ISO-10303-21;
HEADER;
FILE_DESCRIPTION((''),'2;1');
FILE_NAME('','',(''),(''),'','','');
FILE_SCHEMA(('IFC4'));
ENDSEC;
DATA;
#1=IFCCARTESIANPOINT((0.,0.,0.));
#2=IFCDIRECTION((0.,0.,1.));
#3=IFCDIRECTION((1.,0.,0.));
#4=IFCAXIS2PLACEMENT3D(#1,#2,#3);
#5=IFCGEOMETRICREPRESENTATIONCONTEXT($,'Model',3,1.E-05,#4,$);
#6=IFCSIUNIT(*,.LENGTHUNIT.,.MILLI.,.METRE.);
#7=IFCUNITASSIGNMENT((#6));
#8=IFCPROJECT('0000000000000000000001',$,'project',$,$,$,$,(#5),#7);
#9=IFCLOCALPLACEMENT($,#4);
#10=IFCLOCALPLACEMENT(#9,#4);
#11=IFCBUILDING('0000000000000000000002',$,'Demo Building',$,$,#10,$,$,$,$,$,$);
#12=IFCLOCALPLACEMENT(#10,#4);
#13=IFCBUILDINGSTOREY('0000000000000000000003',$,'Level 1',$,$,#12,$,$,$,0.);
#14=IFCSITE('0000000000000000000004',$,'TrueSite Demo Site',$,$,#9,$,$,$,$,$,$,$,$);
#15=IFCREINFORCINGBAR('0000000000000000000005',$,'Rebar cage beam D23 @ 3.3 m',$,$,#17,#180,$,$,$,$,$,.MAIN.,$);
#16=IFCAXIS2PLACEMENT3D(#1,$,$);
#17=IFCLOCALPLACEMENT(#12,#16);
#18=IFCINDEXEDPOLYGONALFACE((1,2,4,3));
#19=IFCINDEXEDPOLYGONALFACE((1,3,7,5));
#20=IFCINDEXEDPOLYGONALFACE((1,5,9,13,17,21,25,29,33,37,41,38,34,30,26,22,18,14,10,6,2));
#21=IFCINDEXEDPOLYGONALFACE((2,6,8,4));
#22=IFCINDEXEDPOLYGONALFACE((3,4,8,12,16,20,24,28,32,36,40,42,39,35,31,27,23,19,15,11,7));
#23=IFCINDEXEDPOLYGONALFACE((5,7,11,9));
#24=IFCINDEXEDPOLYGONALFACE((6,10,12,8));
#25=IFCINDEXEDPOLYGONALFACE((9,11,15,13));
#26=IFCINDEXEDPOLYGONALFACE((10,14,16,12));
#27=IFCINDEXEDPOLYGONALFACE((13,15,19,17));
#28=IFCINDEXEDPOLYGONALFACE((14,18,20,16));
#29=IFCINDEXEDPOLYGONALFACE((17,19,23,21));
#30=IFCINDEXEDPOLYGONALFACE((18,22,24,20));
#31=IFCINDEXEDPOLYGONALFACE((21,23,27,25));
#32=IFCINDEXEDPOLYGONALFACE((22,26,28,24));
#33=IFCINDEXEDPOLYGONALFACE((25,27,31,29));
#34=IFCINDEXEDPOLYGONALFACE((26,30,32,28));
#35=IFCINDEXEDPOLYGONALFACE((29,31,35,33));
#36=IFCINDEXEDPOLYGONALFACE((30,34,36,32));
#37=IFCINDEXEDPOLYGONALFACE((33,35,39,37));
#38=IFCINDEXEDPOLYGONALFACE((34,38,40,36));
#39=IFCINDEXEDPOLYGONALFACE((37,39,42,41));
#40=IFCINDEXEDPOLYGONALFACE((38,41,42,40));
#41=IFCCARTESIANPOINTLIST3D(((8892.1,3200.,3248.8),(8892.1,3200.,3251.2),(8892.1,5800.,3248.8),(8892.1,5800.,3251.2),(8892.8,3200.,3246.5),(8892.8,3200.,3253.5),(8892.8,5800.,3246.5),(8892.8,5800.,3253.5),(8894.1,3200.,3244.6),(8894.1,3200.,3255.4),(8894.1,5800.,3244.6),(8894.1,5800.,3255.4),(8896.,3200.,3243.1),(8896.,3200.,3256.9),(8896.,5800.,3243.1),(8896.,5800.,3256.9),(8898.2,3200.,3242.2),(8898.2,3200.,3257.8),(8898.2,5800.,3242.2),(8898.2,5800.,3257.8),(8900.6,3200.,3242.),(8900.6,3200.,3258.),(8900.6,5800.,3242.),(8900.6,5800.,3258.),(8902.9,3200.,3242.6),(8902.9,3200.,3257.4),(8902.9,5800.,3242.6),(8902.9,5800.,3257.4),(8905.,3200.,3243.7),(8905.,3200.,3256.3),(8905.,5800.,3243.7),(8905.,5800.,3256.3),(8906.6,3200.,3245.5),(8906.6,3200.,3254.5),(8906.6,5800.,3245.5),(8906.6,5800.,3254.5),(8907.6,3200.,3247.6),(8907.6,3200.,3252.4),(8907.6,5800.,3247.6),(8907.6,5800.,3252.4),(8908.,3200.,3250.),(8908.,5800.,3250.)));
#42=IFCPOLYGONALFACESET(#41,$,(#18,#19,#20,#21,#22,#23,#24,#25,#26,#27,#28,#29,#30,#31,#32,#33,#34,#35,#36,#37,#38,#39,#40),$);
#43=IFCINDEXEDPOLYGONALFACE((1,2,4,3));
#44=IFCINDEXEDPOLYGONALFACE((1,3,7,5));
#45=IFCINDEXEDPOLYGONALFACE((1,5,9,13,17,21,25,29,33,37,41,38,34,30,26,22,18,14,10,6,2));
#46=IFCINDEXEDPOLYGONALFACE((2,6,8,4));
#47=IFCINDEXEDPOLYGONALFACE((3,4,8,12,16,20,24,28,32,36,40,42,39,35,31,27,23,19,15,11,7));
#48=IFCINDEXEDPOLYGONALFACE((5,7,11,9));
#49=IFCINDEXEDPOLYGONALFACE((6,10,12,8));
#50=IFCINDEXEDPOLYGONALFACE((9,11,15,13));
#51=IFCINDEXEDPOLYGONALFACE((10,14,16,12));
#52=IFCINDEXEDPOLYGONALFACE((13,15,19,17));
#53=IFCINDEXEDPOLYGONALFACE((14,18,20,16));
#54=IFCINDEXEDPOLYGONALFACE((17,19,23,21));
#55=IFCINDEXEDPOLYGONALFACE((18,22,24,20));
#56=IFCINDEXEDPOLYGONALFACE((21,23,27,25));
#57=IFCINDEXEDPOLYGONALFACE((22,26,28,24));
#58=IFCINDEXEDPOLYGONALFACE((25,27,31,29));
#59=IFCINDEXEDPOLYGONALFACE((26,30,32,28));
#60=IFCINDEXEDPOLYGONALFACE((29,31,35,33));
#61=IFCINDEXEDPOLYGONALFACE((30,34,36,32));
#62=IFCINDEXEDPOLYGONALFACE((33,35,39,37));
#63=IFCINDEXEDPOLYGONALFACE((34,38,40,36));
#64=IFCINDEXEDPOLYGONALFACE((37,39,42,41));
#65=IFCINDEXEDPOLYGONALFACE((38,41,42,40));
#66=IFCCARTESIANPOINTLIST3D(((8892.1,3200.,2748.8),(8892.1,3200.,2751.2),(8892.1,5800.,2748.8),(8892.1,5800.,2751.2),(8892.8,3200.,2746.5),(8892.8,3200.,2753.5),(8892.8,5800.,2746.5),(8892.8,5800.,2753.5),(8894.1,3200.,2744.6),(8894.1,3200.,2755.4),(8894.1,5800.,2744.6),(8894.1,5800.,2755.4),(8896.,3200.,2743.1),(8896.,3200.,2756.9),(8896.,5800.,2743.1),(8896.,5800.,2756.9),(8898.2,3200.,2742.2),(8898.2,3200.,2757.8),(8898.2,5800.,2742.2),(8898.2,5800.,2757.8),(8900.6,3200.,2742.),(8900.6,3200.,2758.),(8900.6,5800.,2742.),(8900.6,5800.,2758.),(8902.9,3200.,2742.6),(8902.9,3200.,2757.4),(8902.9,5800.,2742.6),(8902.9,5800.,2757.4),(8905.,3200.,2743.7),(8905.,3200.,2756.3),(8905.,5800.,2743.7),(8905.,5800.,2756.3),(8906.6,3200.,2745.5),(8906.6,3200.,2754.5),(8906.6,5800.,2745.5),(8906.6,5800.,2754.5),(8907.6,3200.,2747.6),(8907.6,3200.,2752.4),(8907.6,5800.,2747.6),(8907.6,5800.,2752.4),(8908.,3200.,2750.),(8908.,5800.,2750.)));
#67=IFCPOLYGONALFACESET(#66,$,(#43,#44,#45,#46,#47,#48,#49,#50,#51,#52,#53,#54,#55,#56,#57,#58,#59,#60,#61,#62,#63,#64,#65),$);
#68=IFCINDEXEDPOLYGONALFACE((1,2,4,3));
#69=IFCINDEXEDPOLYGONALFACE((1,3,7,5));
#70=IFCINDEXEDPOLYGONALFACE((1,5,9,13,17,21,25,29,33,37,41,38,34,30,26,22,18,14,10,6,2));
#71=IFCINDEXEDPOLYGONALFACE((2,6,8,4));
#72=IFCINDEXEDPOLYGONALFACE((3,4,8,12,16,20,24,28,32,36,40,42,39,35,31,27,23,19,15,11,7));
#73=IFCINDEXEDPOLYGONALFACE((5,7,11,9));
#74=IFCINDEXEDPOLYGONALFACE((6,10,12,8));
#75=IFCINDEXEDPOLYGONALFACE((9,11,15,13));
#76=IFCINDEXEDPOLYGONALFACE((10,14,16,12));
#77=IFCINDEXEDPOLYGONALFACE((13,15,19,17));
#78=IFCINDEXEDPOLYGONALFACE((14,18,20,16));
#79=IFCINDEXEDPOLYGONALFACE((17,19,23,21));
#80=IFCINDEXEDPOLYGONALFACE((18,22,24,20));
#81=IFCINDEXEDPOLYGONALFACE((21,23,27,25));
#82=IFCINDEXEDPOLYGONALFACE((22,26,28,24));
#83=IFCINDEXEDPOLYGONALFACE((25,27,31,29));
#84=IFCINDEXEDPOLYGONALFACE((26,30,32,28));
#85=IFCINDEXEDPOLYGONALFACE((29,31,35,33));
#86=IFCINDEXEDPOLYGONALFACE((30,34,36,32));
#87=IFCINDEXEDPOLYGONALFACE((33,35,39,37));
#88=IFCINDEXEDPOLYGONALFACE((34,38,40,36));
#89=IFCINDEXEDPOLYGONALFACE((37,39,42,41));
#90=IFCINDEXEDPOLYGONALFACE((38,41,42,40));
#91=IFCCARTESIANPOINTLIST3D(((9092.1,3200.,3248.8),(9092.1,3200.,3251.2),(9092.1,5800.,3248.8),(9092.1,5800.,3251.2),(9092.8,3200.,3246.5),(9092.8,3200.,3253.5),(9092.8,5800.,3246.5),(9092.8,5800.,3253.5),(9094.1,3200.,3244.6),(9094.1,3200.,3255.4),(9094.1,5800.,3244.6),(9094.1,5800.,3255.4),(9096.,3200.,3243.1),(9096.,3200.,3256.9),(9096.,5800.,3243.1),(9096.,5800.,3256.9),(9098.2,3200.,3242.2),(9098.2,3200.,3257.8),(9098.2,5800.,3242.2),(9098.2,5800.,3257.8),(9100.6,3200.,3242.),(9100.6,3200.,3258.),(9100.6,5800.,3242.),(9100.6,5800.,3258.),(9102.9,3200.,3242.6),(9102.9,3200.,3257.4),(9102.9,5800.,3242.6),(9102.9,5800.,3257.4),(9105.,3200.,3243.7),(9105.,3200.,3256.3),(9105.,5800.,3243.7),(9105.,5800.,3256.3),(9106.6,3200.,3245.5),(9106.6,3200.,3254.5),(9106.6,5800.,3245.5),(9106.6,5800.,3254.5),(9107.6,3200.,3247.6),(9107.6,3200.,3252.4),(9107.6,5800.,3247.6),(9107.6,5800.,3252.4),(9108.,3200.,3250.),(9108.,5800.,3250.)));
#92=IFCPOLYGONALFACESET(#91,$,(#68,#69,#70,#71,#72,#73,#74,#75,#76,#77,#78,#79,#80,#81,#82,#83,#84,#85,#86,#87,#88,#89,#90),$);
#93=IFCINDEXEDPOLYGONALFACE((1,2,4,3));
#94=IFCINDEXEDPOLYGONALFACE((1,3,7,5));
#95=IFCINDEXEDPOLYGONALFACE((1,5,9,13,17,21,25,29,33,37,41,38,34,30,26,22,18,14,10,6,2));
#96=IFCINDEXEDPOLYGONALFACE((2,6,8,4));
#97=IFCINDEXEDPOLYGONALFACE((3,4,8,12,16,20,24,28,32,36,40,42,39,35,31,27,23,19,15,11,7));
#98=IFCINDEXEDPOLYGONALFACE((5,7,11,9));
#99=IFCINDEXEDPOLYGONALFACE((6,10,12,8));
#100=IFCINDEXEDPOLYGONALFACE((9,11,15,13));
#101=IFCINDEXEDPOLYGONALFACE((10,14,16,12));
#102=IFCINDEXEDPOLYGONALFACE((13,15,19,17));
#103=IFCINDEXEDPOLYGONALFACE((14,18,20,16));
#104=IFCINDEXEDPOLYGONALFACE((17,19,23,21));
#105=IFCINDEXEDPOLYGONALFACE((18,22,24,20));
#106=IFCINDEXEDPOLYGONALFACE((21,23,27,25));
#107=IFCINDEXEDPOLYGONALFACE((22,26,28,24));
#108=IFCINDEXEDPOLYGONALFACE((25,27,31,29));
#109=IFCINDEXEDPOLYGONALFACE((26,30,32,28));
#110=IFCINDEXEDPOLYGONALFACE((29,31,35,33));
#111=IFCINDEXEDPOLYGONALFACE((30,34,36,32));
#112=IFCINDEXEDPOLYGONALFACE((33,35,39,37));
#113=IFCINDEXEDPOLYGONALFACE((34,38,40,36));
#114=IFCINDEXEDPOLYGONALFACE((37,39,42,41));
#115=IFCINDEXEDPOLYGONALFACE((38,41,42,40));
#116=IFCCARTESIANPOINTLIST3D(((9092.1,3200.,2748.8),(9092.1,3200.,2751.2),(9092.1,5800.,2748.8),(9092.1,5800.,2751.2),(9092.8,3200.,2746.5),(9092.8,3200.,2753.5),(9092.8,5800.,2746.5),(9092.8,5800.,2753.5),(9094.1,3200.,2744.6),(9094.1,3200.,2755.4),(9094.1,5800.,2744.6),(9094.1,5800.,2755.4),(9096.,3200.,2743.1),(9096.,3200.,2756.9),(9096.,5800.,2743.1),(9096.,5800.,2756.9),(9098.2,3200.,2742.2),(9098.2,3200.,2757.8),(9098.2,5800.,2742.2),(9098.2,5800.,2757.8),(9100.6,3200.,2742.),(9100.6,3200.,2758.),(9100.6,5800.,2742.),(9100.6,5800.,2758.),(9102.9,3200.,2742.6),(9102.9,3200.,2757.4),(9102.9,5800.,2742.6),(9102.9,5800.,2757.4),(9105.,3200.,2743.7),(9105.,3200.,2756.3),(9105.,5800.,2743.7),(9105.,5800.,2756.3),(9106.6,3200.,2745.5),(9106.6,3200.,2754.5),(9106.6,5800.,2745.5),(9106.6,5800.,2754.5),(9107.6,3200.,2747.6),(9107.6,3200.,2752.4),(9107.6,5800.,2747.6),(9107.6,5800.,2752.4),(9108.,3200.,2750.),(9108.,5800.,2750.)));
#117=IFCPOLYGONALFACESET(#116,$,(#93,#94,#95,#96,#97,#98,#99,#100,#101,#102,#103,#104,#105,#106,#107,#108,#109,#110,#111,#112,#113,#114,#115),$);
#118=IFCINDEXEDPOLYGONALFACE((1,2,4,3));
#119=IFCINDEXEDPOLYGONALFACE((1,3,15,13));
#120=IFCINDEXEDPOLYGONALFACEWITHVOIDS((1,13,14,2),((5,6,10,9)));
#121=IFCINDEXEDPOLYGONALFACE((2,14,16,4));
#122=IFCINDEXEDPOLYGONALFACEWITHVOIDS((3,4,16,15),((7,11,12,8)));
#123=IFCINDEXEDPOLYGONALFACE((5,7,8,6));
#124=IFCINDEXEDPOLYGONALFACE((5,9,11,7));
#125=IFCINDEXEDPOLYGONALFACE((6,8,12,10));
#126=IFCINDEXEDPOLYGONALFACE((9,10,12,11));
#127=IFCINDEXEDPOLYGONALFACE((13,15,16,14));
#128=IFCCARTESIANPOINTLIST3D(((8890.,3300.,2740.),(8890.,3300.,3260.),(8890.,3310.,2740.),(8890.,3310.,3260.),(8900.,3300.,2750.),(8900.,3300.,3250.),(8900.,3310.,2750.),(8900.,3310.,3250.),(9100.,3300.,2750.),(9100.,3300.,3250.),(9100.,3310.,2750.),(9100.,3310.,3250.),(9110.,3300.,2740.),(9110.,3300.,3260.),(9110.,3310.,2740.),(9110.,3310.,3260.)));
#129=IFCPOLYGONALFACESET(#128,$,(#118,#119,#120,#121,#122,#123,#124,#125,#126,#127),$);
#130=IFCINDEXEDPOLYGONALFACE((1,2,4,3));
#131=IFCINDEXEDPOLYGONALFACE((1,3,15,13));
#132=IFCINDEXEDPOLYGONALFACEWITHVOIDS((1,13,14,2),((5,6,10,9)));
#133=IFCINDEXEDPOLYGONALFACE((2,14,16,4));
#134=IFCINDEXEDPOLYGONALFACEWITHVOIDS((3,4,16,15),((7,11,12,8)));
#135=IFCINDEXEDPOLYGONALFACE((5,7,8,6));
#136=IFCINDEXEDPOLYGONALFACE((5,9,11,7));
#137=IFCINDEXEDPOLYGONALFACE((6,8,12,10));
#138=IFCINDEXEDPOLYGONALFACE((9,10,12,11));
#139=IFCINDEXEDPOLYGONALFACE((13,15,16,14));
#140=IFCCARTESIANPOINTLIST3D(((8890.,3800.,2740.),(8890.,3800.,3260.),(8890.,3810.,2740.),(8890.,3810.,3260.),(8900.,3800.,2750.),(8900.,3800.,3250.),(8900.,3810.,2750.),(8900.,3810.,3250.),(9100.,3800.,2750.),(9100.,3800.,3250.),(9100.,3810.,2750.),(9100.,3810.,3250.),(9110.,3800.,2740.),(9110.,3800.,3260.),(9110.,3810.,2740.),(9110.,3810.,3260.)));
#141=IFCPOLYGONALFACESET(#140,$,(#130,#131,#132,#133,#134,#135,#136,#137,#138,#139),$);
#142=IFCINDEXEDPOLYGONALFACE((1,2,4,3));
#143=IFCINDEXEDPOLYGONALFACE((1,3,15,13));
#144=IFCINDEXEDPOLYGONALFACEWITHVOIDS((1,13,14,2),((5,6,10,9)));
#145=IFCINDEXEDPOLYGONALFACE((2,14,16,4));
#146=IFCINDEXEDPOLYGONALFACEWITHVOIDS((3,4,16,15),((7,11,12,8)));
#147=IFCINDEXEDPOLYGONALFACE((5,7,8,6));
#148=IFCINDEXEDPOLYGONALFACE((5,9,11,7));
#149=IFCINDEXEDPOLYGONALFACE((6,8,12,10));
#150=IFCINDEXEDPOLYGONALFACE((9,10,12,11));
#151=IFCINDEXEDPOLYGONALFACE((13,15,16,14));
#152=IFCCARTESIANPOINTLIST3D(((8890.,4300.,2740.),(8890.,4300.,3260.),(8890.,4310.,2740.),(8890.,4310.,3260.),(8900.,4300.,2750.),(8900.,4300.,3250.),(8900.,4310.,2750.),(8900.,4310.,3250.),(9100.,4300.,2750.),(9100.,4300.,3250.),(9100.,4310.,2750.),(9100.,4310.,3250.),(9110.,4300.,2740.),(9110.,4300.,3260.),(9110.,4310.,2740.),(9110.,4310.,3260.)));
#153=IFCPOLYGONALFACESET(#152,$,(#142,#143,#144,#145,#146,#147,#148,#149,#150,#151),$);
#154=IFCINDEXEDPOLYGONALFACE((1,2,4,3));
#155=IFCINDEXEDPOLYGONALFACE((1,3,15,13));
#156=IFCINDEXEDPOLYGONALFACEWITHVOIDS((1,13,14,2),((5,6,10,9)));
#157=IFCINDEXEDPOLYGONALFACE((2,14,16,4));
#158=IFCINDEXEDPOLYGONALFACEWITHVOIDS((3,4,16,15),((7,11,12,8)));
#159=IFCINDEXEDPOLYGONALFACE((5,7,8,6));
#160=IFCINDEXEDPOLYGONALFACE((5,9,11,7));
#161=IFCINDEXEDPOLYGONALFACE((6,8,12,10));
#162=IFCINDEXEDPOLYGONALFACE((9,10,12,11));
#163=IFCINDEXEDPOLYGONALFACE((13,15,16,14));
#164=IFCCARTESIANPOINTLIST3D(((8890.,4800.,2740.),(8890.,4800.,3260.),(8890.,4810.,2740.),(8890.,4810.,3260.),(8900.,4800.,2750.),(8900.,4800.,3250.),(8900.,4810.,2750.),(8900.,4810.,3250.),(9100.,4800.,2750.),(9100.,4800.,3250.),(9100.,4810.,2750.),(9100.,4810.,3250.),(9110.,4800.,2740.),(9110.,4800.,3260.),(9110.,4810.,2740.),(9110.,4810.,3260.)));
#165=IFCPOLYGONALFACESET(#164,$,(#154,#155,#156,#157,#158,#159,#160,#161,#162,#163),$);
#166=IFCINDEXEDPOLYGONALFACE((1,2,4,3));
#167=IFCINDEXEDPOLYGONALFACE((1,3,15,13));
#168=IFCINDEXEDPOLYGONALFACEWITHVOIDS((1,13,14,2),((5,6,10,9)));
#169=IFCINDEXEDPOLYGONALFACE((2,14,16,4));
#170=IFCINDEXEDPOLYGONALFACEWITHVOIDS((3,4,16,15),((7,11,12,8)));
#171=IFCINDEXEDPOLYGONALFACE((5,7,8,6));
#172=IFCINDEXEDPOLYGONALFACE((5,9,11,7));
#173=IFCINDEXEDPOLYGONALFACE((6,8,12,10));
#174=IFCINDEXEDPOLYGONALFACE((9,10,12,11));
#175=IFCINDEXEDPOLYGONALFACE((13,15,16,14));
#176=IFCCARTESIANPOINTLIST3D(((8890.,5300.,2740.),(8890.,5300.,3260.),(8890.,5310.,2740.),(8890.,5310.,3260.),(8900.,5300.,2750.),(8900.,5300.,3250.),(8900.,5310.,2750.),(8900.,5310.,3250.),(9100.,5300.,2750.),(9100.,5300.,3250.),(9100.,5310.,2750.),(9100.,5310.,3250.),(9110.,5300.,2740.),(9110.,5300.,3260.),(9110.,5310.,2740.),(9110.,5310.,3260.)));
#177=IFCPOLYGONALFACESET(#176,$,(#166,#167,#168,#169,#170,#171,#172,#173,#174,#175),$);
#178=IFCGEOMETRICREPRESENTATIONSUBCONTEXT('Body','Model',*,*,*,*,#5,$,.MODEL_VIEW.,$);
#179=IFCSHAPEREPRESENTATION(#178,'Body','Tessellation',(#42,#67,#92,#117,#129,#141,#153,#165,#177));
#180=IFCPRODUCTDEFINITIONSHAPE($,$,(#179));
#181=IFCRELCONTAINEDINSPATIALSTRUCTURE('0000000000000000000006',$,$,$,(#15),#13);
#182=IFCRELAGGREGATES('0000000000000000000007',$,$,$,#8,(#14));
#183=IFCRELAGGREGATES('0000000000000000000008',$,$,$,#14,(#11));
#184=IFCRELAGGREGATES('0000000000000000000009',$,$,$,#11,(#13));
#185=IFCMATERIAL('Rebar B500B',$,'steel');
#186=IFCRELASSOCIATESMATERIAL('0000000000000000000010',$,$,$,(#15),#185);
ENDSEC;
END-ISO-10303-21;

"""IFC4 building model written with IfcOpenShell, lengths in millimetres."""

from ifc_helpers import new_model, si_unit, frame, origin_with_axes, place, context, subcontext, project, spatial, hollow_rectangle, circle, extrude, material, element, save


model = new_model("IFC4")

# Units and contexts
model_context = context("Model", 3, precision=1e-05, world=origin_with_axes())
body_context = subcontext(model_context, "Body", "Model", "MODEL_VIEW")
ifc_project = project(units=[si_unit("LENGTHUNIT", "METRE", prefix="MILLI")], contexts=[model_context])

# Site, building, storey
site_placement = place(None, origin_with_axes())
site = spatial("IfcSite", under=ifc_project, at=site_placement, Name="TrueSite Demo Site")
building_placement = place(site_placement, origin_with_axes())
building = spatial("IfcBuilding", under=site, at=building_placement, Name="Demo Building")
storey_placement = place(building_placement, origin_with_axes())
storey = spatial("IfcBuildingStorey", under=building, at=storey_placement, Name="Level 1", Elevation=0.0)

# Reinforcing bar
ifc_material_1 = material(Name="Rebar B500B", Category="steel")
for number, where, z_axis, x_axis, name in (
    (1, (9000.0, 3200.0, 3000.0), (0.0, 1.0, 0.0), (1.0, 0.0, 0.0), "Rebar cage beam D23 @ 3.3 m"),
):
    element("IfcReinforcingBar", number, at=place(storey_placement, frame(where, z_axis=z_axis, x_axis=x_axis)), inside=storey, material=ifc_material_1, Name=name, PredefinedType="MAIN", context=body_context, shape_type="SweptSolid", body=[
        extrude(circle(Radius=8.0), frame((-100.0, -250.0, 0.0)), (0.0, 0.0, 1.0), 2600.0),
        extrude(circle(Radius=8.0), frame((-100.0, 250.0, 0.0)), (0.0, 0.0, 1.0), 2600.0),
        extrude(circle(Radius=8.0), frame((100.0, -250.0, 0.0)), (0.0, 0.0, 1.0), 2600.0),
        extrude(circle(Radius=8.0), frame((100.0, 250.0, 0.0)), (0.0, 0.0, 1.0), 2600.0),
        extrude(hollow_rectangle(XDim=220.0, YDim=520.0, WallThickness=10.0), frame((0.0, 0.0, 100.0)), (0.0, 0.0, 1.0), 10.0),
        extrude(hollow_rectangle(XDim=220.0, YDim=520.0, WallThickness=10.0), frame((0.0, 0.0, 600.0)), (0.0, 0.0, 1.0), 10.0),
        extrude(hollow_rectangle(XDim=220.0, YDim=520.0, WallThickness=10.0), frame((0.0, 0.0, 1100.0)), (0.0, 0.0, 1.0), 10.0),
        extrude(hollow_rectangle(XDim=220.0, YDim=520.0, WallThickness=10.0), frame((0.0, 0.0, 1600.0)), (0.0, 0.0, 1.0), 10.0),
        extrude(hollow_rectangle(XDim=220.0, YDim=520.0, WallThickness=10.0), frame((0.0, 0.0, 2100.0)), (0.0, 0.0, 1.0), 10.0),
    ])

save(model, "model.ifc")
